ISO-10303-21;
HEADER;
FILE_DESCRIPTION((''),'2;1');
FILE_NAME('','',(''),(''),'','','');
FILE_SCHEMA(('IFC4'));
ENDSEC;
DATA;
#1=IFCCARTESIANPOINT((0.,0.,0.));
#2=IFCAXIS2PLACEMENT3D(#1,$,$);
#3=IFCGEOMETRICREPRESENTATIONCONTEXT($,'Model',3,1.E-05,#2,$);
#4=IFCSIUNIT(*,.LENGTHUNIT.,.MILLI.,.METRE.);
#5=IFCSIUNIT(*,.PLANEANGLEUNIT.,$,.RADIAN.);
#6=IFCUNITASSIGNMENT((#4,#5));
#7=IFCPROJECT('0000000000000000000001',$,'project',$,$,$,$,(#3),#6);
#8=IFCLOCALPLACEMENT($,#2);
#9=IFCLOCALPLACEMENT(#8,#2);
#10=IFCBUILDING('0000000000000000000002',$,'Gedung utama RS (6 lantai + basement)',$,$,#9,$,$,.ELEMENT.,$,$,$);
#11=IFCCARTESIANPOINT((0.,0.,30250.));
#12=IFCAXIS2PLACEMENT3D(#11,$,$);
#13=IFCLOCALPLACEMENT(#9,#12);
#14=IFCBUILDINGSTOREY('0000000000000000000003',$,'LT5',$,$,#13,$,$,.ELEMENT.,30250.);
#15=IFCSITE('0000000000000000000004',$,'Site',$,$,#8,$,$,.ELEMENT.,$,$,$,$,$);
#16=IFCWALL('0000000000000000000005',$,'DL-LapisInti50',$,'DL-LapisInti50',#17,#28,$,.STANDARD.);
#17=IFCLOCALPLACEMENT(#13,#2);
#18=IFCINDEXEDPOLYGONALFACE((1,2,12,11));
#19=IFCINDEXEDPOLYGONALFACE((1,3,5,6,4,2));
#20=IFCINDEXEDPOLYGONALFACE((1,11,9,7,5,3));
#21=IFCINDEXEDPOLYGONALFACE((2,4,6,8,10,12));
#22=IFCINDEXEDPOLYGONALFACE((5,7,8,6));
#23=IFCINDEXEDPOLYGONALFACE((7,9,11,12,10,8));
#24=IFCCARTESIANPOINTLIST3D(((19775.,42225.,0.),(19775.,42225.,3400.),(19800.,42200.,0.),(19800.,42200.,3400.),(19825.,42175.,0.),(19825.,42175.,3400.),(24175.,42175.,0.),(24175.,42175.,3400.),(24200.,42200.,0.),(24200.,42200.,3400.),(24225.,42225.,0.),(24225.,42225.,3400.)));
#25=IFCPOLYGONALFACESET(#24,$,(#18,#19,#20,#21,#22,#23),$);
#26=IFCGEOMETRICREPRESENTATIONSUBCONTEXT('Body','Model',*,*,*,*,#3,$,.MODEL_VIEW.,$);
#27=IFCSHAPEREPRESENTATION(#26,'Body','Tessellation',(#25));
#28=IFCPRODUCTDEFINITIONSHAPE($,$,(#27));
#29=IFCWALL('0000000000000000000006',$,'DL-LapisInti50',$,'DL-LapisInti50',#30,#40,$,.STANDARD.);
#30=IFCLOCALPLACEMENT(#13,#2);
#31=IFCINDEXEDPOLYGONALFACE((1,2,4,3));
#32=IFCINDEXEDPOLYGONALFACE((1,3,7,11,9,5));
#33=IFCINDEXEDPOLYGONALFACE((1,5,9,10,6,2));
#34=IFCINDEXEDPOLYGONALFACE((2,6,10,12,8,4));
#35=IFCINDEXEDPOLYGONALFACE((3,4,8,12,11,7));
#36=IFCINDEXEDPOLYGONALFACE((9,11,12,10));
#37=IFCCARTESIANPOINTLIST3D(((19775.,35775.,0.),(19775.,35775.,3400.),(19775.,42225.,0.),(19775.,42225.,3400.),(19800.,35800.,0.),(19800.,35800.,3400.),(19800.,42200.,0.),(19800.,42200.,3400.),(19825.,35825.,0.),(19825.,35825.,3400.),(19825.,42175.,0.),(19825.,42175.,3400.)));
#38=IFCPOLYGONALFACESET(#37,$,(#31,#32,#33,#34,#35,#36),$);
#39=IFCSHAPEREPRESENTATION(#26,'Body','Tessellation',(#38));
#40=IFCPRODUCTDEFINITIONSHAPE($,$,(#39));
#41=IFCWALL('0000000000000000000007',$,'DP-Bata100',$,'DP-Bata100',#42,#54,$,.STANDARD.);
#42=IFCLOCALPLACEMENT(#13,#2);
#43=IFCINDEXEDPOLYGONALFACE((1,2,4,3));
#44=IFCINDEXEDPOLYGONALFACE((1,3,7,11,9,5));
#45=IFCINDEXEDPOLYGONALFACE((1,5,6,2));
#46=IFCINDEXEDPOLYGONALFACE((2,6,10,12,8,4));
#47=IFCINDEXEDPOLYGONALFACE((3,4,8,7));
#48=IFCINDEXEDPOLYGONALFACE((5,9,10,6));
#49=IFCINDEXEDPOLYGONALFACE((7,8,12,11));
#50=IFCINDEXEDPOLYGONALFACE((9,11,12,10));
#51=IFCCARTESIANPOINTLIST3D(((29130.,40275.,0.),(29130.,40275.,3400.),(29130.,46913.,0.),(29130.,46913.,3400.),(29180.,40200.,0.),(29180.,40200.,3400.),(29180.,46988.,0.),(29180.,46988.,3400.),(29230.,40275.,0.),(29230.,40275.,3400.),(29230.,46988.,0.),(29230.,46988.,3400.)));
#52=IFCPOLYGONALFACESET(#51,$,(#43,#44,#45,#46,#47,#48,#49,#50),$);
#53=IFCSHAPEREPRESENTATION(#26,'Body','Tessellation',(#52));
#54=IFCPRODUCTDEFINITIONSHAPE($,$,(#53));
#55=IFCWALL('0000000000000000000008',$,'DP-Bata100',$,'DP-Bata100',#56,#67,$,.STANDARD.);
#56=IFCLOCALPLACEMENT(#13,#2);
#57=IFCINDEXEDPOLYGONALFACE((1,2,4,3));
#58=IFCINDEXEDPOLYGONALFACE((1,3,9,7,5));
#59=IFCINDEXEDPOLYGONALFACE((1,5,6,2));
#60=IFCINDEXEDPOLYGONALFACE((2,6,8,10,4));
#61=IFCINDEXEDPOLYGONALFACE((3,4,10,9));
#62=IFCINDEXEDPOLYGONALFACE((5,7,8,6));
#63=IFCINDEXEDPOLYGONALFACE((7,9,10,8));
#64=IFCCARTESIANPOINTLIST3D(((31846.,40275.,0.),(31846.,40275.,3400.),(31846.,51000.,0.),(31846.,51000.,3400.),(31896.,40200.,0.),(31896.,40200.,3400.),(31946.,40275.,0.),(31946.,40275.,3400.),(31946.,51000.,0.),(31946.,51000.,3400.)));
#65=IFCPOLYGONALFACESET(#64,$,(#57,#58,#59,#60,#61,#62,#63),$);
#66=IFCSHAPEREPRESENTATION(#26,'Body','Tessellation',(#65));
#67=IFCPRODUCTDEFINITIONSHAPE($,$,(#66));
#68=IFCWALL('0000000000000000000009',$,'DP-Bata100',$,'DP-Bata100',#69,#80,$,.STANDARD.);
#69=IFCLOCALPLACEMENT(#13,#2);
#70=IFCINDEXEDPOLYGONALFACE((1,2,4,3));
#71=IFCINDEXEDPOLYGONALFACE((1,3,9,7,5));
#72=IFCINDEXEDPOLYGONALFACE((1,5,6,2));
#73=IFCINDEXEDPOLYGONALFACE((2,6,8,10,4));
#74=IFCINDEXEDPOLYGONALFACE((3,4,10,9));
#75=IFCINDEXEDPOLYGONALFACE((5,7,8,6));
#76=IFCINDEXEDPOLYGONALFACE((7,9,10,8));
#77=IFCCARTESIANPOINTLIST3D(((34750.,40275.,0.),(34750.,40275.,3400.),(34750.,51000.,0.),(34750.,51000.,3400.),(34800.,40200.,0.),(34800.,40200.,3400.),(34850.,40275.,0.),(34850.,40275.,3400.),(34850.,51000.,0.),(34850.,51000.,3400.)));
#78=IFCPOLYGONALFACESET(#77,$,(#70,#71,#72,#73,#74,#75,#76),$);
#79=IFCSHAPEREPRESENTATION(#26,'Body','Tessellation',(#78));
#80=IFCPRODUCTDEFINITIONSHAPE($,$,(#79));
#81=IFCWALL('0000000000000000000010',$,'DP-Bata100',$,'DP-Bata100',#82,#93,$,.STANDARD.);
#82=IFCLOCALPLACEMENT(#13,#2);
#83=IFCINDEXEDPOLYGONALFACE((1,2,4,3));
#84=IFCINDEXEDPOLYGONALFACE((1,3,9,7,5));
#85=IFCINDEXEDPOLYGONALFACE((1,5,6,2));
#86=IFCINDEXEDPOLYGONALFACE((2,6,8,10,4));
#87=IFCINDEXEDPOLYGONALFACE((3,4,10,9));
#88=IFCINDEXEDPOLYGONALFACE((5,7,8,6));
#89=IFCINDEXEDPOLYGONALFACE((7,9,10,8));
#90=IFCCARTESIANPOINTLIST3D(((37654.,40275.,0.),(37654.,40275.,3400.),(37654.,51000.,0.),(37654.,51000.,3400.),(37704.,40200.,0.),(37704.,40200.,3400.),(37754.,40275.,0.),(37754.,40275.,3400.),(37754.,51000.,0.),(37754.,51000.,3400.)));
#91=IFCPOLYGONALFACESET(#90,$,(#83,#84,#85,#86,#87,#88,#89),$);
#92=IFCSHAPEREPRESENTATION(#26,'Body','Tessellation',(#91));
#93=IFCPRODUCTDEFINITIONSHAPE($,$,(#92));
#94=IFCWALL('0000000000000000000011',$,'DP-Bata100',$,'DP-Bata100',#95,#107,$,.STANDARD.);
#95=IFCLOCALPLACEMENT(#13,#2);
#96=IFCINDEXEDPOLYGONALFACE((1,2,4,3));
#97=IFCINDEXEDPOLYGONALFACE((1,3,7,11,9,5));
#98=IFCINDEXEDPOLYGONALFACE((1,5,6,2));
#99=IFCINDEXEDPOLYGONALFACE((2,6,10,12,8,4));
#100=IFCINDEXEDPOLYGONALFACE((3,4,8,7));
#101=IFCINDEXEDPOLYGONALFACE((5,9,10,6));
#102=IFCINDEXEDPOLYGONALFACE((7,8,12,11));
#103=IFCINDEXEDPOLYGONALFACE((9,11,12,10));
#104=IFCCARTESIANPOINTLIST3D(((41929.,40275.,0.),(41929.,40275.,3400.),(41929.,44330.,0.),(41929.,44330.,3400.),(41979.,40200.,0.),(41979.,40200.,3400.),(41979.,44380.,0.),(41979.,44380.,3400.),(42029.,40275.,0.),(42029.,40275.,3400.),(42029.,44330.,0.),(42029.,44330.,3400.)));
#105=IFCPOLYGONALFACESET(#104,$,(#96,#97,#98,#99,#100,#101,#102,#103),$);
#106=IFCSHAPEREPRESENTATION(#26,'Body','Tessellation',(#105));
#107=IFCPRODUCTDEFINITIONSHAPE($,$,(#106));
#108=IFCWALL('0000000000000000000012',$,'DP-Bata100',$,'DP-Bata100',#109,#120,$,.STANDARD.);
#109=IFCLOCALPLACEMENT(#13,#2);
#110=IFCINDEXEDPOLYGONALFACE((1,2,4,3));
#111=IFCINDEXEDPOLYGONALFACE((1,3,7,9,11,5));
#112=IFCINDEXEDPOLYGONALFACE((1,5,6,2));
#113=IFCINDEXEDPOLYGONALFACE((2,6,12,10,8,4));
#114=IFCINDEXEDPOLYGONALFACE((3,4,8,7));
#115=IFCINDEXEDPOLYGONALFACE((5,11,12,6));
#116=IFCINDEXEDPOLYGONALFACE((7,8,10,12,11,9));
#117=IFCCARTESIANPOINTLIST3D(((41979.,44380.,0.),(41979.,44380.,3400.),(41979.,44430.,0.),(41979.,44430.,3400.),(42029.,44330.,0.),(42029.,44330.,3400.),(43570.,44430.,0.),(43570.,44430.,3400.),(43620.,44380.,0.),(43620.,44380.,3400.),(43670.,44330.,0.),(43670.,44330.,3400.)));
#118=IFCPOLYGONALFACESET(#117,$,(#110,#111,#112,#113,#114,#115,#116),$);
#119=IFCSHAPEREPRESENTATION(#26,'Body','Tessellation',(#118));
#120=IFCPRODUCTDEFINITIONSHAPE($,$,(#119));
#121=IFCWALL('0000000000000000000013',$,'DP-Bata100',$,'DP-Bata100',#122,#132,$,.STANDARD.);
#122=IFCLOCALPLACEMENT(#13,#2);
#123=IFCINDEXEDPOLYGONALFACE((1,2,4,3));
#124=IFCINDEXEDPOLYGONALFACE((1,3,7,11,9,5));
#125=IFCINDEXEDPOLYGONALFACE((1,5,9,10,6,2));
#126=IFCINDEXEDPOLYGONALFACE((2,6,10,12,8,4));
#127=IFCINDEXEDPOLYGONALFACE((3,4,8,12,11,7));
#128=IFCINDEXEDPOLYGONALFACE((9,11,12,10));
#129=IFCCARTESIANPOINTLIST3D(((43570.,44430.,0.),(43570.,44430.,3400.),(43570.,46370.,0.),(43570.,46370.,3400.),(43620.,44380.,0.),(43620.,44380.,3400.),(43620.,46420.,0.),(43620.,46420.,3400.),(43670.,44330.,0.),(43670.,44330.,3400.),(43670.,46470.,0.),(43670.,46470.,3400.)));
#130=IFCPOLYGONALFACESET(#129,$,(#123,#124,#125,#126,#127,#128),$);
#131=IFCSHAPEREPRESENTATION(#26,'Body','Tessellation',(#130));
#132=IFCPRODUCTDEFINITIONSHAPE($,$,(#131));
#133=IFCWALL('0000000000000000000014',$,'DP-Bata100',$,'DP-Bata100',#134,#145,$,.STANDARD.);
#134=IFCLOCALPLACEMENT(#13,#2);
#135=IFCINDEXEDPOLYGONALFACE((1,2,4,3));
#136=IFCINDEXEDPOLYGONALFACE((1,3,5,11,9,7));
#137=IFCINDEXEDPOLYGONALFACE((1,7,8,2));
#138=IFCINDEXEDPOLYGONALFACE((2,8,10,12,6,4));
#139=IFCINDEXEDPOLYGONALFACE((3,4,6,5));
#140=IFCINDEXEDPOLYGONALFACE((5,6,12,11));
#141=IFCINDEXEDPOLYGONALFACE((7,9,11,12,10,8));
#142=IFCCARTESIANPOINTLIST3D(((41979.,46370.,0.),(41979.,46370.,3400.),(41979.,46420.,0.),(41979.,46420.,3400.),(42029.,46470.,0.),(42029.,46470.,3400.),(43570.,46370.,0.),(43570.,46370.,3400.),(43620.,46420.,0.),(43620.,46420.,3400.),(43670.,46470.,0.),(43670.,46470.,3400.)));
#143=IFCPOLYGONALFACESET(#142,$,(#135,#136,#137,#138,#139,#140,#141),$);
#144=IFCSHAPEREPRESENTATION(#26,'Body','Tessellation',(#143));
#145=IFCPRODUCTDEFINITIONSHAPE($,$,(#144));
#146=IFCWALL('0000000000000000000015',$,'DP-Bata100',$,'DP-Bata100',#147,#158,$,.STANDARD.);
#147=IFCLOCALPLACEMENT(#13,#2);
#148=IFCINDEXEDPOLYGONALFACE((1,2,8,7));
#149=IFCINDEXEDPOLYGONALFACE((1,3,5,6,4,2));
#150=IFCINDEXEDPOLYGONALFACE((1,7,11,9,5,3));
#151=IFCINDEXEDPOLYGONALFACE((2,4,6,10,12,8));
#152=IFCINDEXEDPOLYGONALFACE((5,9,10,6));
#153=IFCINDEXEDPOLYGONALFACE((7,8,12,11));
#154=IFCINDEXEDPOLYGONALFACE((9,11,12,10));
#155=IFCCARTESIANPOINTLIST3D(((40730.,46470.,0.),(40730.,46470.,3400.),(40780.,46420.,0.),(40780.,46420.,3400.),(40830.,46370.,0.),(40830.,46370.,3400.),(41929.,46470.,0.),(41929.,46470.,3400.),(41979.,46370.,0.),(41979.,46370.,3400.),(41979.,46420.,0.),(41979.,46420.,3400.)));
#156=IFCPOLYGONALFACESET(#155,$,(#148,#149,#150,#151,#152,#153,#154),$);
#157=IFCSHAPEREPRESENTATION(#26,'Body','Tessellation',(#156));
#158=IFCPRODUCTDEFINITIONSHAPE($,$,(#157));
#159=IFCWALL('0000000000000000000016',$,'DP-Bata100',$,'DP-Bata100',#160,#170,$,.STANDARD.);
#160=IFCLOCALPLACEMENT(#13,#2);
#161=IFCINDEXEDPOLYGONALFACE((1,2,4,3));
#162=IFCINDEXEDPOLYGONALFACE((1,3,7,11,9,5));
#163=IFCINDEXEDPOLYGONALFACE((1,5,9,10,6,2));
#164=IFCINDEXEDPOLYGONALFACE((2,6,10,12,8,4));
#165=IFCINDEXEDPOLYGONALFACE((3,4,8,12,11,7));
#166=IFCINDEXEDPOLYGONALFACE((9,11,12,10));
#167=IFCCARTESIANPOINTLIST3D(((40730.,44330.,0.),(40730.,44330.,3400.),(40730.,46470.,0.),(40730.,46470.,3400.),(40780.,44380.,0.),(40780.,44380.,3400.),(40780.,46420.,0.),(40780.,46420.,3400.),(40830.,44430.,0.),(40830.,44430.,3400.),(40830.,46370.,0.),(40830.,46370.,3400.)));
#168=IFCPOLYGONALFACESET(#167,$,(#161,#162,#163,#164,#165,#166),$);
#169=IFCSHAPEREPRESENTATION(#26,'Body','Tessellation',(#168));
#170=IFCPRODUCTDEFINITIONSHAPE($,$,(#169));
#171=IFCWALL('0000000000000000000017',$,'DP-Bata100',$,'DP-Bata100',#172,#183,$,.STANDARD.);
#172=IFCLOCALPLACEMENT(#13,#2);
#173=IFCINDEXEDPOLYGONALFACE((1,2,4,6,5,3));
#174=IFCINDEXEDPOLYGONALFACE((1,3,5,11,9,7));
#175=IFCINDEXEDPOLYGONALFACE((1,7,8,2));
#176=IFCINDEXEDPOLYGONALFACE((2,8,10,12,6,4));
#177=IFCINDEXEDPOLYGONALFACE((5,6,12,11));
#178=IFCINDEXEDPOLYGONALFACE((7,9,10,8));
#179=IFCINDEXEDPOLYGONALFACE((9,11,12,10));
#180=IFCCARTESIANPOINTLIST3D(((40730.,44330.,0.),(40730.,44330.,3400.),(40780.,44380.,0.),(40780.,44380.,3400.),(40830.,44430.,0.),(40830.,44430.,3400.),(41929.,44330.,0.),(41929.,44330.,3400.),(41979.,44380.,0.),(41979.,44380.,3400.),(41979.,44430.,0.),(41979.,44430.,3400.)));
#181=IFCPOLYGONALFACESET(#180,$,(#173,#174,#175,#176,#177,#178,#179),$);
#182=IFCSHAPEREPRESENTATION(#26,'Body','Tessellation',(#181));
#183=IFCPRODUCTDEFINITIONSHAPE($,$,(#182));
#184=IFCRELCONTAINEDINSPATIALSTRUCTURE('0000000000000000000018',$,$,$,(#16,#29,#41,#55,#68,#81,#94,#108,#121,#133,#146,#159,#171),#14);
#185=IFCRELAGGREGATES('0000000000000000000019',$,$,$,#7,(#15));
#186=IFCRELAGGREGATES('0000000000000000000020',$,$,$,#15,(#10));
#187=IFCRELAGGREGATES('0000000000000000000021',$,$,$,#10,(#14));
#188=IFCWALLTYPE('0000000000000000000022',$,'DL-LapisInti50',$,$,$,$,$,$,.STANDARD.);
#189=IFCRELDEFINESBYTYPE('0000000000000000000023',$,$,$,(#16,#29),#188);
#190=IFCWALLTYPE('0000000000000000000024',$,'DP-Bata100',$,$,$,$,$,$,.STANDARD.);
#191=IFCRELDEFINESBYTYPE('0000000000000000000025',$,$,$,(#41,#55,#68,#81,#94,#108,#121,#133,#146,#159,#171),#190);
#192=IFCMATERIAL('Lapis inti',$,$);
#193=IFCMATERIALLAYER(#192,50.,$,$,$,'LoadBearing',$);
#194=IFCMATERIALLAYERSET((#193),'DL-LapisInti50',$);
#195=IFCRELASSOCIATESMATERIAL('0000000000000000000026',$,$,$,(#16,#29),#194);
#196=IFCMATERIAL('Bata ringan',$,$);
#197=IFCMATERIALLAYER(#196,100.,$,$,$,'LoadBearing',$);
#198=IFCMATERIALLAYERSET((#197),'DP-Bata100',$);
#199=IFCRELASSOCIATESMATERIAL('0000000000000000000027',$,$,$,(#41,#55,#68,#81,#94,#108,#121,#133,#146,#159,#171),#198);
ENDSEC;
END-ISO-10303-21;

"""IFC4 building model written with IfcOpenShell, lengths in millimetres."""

from ifc_helpers import new_model, si_unit, frame, origin, place, context, subcontext, project, spatial, polyline, outline, extrude, material, layer, layer_set, layer_usage, type_object, element, save


model = new_model("IFC4")

# Units and contexts
model_context = context("Model", 3, precision=1e-05, world=origin())
body_context = subcontext(model_context, "Body", "Model", "MODEL_VIEW")
ifc_project = project(units=[si_unit("LENGTHUNIT", "METRE", prefix="MILLI"), si_unit("PLANEANGLEUNIT", "RADIAN")], contexts=[model_context])

# Site, building, storey
site_placement = place(None, origin())
site = spatial("IfcSite", under=ifc_project, at=site_placement, Name="Site", CompositionType="ELEMENT")
building_placement = place(site_placement, origin())
building = spatial("IfcBuilding", under=site, at=building_placement, Name="Gedung utama RS (6 lantai + basement)", CompositionType="ELEMENT")
storey_placement = place(building_placement, frame((0.0, 0.0, 30250.0)))
storey = spatial("IfcBuildingStorey", under=building, at=storey_placement, Name="LT5", CompositionType="ELEMENT", Elevation=30250.0)

# Walls
ifc_material_1 = material(Name="Lapis inti")
ifc_layer_1 = layer(ifc_material_1, 50.0, Category="LoadBearing")
ifc_layer_set_1 = layer_set([ifc_layer_1], Name="DL-LapisInti50")
ifc_layer_usage_1 = layer_usage(ifc_layer_set_1, "AXIS2", "NEGATIVE", 25.0)
wall_type_1 = type_object("IfcWallType", Name="DL-LapisInti50", PredefinedType="STANDARD")
wall_1_placement = place(storey_placement, frame((24200.0, 42200.0, 0.0), z_axis=(0.0, 0.0, 1.0), x_axis=(-1.0, 0.0, 0.0)))
element("IfcWall", 1, at=wall_1_placement, inside=storey, type_object=wall_type_1, material=ifc_layer_usage_1, Name="DL-LapisInti50", ObjectType="DL-LapisInti50", PredefinedType="STANDARD", context=body_context, shape_type="SweptSolid", body=[
    extrude(outline(polyline([(-25.0, -25.0), (0.0, 0.0), (25.0, 25.0), (4375.0, 25.0), (4400.0, 0.0), (4425.0, -25.0), (-25.0, -25.0)])), origin(), (0.0, 0.0, 1.0), 3400.0),
])
wall_2_placement = place(storey_placement, frame((19800.0, 42200.0, 0.0), z_axis=(0.0, 0.0, 1.0), x_axis=(0.0, -1.0, 0.0)))
element("IfcWall", 2, at=wall_2_placement, inside=storey, type_object=wall_type_1, material=ifc_layer_usage_1, Name="DL-LapisInti50", ObjectType="DL-LapisInti50", PredefinedType="STANDARD", context=body_context, shape_type="SweptSolid", body=[
    extrude(outline(polyline([(-25.0, -25.0), (0.0, 0.0), (25.0, 25.0), (6375.0, 25.0), (6400.0, 0.0), (6425.0, -25.0), (-25.0, -25.0)])), origin(), (0.0, 0.0, 1.0), 3400.0),
])
ifc_material_2 = material(Name="Bata ringan")
ifc_layer_2 = layer(ifc_material_2, 100.0, Category="LoadBearing")
ifc_layer_set_2 = layer_set([ifc_layer_2], Name="DP-Bata100")
ifc_layer_usage_2 = layer_usage(ifc_layer_set_2, "AXIS2", "NEGATIVE", 50.0)
wall_type_2 = type_object("IfcWallType", Name="DP-Bata100", PredefinedType="STANDARD")
wall_3_placement = place(storey_placement, frame((29180.0, 46988.0, 0.0), z_axis=(0.0, 0.0, 1.0), x_axis=(0.0, -1.0, 0.0)))
element("IfcWall", 3, at=wall_3_placement, inside=storey, type_object=wall_type_2, material=ifc_layer_usage_2, Name="DP-Bata100", ObjectType="DP-Bata100", PredefinedType="STANDARD", context=body_context, shape_type="SweptSolid", body=[
    extrude(outline(polyline([(75.0, -50.0), (0.0, 0.0), (0.0, 50.0), (6713.0, 50.0), (6788.0, 0.0), (6713.0, -50.0), (75.0, -50.0)])), origin(), (0.0, 0.0, 1.0), 3400.0),
])
for number, where, z_axis, x_axis, name in (
    (4, (31896.0, 40200.0, 0.0), (0.0, 0.0, 1.0), (0.0, 1.0, 0.0), "DP-Bata100"),
    (5, (34800.0, 40200.0, 0.0), (0.0, 0.0, 1.0), (0.0, 1.0, 0.0), "DP-Bata100"),
    (6, (37704.0, 40200.0, 0.0), (0.0, 0.0, 1.0), (0.0, 1.0, 0.0), "DP-Bata100"),
):
    element("IfcWall", number, at=place(storey_placement, frame(where, z_axis=z_axis, x_axis=x_axis)), inside=storey, type_object=wall_type_2, material=ifc_layer_usage_2, Name=name, ObjectType="DP-Bata100", PredefinedType="STANDARD", context=body_context, shape_type="SweptSolid", body=[
        extrude(outline(polyline([(75.0, -50.0), (0.0, 0.0), (75.0, 50.0), (10800.0, 50.0), (10800.0, -50.0), (75.0, -50.0)])), origin(), (0.0, 0.0, 1.0), 3400.0),
    ])
wall_4_placement = place(storey_placement, frame((41979.0, 44380.0, 0.0), z_axis=(0.0, 0.0, 1.0), x_axis=(0.0, -1.0, 0.0)))
element("IfcWall", 7, at=wall_4_placement, inside=storey, type_object=wall_type_2, material=ifc_layer_usage_2, Name="DP-Bata100", ObjectType="DP-Bata100", PredefinedType="STANDARD", context=body_context, shape_type="SweptSolid", body=[
    extrude(outline(polyline([(50.0, -50.0), (0.0, 0.0), (50.0, 50.0), (4105.0, 50.0), (4180.0, 0.0), (4105.0, -50.0), (50.0, -50.0)])), origin(), (0.0, 0.0, 1.0), 3400.0),
])
wall_5_placement = place(storey_placement, frame((41979.0, 44380.0, 0.0), z_axis=(0.0, 0.0, 1.0), x_axis=(1.0, 0.0, 0.0)))
element("IfcWall", 8, at=wall_5_placement, inside=storey, type_object=wall_type_2, material=ifc_layer_usage_2, Name="DP-Bata100", ObjectType="DP-Bata100", PredefinedType="STANDARD", context=body_context, shape_type="SweptSolid", body=[
    extrude(outline(polyline([(50.0, -50.0), (0.0, 0.0), (0.0, 50.0), (1591.0, 50.0), (1641.0, 0.0), (1691.0, -50.0), (50.0, -50.0)])), origin(), (0.0, 0.0, 1.0), 3400.0),
])
wall_6_placement = place(storey_placement, frame((43620.0, 44380.0, 0.0), z_axis=(0.0, 0.0, 1.0), x_axis=(0.0, 1.0, 0.0)))
element("IfcWall", 9, at=wall_6_placement, inside=storey, type_object=wall_type_2, material=ifc_layer_usage_2, Name="DP-Bata100", ObjectType="DP-Bata100", PredefinedType="STANDARD", context=body_context, shape_type="SweptSolid", body=[
    extrude(outline(polyline([(-50.0, -50.0), (0.0, 0.0), (50.0, 50.0), (1990.0, 50.0), (2040.0, 0.0), (2090.0, -50.0), (-50.0, -50.0)])), origin(), (0.0, 0.0, 1.0), 3400.0),
])
wall_7_placement = place(storey_placement, frame((43620.0, 46420.0, 0.0), z_axis=(0.0, 0.0, 1.0), x_axis=(-1.0, 0.0, 0.0)))
element("IfcWall", 10, at=wall_7_placement, inside=storey, type_object=wall_type_2, material=ifc_layer_usage_2, Name="DP-Bata100", ObjectType="DP-Bata100", PredefinedType="STANDARD", context=body_context, shape_type="SweptSolid", body=[
    extrude(outline(polyline([(-50.0, -50.0), (0.0, 0.0), (50.0, 50.0), (1641.0, 50.0), (1641.0, 0.0), (1591.0, -50.0), (-50.0, -50.0)])), origin(), (0.0, 0.0, 1.0), 3400.0),
])
wall_8_placement = place(storey_placement, frame((41979.0, 46420.0, 0.0), z_axis=(0.0, 0.0, 1.0), x_axis=(-1.0, 0.0, 0.0)))
element("IfcWall", 11, at=wall_8_placement, inside=storey, type_object=wall_type_2, material=ifc_layer_usage_2, Name="DP-Bata100", ObjectType="DP-Bata100", PredefinedType="STANDARD", context=body_context, shape_type="SweptSolid", body=[
    extrude(outline(polyline([(50.0, -50.0), (0.0, 0.0), (0.0, 50.0), (1149.0, 50.0), (1199.0, 0.0), (1249.0, -50.0), (50.0, -50.0)])), origin(), (0.0, 0.0, 1.0), 3400.0),
])
wall_9_placement = place(storey_placement, frame((40780.0, 46420.0, 0.0), z_axis=(0.0, 0.0, 1.0), x_axis=(0.0, -1.0, 0.0)))
element("IfcWall", 12, at=wall_9_placement, inside=storey, type_object=wall_type_2, material=ifc_layer_usage_2, Name="DP-Bata100", ObjectType="DP-Bata100", PredefinedType="STANDARD", context=body_context, shape_type="SweptSolid", body=[
    extrude(outline(polyline([(-50.0, -50.0), (0.0, 0.0), (50.0, 50.0), (1990.0, 50.0), (2040.0, 0.0), (2090.0, -50.0), (-50.0, -50.0)])), origin(), (0.0, 0.0, 1.0), 3400.0),
])
wall_10_placement = place(storey_placement, frame((40780.0, 44380.0, 0.0), z_axis=(0.0, 0.0, 1.0), x_axis=(1.0, 0.0, 0.0)))
element("IfcWall", 13, at=wall_10_placement, inside=storey, type_object=wall_type_2, material=ifc_layer_usage_2, Name="DP-Bata100", ObjectType="DP-Bata100", PredefinedType="STANDARD", context=body_context, shape_type="SweptSolid", body=[
    extrude(outline(polyline([(-50.0, -50.0), (0.0, 0.0), (50.0, 50.0), (1199.0, 50.0), (1199.0, 0.0), (1149.0, -50.0), (-50.0, -50.0)])), origin(), (0.0, 0.0, 1.0), 3400.0),
])

save(model, "model.ifc")
